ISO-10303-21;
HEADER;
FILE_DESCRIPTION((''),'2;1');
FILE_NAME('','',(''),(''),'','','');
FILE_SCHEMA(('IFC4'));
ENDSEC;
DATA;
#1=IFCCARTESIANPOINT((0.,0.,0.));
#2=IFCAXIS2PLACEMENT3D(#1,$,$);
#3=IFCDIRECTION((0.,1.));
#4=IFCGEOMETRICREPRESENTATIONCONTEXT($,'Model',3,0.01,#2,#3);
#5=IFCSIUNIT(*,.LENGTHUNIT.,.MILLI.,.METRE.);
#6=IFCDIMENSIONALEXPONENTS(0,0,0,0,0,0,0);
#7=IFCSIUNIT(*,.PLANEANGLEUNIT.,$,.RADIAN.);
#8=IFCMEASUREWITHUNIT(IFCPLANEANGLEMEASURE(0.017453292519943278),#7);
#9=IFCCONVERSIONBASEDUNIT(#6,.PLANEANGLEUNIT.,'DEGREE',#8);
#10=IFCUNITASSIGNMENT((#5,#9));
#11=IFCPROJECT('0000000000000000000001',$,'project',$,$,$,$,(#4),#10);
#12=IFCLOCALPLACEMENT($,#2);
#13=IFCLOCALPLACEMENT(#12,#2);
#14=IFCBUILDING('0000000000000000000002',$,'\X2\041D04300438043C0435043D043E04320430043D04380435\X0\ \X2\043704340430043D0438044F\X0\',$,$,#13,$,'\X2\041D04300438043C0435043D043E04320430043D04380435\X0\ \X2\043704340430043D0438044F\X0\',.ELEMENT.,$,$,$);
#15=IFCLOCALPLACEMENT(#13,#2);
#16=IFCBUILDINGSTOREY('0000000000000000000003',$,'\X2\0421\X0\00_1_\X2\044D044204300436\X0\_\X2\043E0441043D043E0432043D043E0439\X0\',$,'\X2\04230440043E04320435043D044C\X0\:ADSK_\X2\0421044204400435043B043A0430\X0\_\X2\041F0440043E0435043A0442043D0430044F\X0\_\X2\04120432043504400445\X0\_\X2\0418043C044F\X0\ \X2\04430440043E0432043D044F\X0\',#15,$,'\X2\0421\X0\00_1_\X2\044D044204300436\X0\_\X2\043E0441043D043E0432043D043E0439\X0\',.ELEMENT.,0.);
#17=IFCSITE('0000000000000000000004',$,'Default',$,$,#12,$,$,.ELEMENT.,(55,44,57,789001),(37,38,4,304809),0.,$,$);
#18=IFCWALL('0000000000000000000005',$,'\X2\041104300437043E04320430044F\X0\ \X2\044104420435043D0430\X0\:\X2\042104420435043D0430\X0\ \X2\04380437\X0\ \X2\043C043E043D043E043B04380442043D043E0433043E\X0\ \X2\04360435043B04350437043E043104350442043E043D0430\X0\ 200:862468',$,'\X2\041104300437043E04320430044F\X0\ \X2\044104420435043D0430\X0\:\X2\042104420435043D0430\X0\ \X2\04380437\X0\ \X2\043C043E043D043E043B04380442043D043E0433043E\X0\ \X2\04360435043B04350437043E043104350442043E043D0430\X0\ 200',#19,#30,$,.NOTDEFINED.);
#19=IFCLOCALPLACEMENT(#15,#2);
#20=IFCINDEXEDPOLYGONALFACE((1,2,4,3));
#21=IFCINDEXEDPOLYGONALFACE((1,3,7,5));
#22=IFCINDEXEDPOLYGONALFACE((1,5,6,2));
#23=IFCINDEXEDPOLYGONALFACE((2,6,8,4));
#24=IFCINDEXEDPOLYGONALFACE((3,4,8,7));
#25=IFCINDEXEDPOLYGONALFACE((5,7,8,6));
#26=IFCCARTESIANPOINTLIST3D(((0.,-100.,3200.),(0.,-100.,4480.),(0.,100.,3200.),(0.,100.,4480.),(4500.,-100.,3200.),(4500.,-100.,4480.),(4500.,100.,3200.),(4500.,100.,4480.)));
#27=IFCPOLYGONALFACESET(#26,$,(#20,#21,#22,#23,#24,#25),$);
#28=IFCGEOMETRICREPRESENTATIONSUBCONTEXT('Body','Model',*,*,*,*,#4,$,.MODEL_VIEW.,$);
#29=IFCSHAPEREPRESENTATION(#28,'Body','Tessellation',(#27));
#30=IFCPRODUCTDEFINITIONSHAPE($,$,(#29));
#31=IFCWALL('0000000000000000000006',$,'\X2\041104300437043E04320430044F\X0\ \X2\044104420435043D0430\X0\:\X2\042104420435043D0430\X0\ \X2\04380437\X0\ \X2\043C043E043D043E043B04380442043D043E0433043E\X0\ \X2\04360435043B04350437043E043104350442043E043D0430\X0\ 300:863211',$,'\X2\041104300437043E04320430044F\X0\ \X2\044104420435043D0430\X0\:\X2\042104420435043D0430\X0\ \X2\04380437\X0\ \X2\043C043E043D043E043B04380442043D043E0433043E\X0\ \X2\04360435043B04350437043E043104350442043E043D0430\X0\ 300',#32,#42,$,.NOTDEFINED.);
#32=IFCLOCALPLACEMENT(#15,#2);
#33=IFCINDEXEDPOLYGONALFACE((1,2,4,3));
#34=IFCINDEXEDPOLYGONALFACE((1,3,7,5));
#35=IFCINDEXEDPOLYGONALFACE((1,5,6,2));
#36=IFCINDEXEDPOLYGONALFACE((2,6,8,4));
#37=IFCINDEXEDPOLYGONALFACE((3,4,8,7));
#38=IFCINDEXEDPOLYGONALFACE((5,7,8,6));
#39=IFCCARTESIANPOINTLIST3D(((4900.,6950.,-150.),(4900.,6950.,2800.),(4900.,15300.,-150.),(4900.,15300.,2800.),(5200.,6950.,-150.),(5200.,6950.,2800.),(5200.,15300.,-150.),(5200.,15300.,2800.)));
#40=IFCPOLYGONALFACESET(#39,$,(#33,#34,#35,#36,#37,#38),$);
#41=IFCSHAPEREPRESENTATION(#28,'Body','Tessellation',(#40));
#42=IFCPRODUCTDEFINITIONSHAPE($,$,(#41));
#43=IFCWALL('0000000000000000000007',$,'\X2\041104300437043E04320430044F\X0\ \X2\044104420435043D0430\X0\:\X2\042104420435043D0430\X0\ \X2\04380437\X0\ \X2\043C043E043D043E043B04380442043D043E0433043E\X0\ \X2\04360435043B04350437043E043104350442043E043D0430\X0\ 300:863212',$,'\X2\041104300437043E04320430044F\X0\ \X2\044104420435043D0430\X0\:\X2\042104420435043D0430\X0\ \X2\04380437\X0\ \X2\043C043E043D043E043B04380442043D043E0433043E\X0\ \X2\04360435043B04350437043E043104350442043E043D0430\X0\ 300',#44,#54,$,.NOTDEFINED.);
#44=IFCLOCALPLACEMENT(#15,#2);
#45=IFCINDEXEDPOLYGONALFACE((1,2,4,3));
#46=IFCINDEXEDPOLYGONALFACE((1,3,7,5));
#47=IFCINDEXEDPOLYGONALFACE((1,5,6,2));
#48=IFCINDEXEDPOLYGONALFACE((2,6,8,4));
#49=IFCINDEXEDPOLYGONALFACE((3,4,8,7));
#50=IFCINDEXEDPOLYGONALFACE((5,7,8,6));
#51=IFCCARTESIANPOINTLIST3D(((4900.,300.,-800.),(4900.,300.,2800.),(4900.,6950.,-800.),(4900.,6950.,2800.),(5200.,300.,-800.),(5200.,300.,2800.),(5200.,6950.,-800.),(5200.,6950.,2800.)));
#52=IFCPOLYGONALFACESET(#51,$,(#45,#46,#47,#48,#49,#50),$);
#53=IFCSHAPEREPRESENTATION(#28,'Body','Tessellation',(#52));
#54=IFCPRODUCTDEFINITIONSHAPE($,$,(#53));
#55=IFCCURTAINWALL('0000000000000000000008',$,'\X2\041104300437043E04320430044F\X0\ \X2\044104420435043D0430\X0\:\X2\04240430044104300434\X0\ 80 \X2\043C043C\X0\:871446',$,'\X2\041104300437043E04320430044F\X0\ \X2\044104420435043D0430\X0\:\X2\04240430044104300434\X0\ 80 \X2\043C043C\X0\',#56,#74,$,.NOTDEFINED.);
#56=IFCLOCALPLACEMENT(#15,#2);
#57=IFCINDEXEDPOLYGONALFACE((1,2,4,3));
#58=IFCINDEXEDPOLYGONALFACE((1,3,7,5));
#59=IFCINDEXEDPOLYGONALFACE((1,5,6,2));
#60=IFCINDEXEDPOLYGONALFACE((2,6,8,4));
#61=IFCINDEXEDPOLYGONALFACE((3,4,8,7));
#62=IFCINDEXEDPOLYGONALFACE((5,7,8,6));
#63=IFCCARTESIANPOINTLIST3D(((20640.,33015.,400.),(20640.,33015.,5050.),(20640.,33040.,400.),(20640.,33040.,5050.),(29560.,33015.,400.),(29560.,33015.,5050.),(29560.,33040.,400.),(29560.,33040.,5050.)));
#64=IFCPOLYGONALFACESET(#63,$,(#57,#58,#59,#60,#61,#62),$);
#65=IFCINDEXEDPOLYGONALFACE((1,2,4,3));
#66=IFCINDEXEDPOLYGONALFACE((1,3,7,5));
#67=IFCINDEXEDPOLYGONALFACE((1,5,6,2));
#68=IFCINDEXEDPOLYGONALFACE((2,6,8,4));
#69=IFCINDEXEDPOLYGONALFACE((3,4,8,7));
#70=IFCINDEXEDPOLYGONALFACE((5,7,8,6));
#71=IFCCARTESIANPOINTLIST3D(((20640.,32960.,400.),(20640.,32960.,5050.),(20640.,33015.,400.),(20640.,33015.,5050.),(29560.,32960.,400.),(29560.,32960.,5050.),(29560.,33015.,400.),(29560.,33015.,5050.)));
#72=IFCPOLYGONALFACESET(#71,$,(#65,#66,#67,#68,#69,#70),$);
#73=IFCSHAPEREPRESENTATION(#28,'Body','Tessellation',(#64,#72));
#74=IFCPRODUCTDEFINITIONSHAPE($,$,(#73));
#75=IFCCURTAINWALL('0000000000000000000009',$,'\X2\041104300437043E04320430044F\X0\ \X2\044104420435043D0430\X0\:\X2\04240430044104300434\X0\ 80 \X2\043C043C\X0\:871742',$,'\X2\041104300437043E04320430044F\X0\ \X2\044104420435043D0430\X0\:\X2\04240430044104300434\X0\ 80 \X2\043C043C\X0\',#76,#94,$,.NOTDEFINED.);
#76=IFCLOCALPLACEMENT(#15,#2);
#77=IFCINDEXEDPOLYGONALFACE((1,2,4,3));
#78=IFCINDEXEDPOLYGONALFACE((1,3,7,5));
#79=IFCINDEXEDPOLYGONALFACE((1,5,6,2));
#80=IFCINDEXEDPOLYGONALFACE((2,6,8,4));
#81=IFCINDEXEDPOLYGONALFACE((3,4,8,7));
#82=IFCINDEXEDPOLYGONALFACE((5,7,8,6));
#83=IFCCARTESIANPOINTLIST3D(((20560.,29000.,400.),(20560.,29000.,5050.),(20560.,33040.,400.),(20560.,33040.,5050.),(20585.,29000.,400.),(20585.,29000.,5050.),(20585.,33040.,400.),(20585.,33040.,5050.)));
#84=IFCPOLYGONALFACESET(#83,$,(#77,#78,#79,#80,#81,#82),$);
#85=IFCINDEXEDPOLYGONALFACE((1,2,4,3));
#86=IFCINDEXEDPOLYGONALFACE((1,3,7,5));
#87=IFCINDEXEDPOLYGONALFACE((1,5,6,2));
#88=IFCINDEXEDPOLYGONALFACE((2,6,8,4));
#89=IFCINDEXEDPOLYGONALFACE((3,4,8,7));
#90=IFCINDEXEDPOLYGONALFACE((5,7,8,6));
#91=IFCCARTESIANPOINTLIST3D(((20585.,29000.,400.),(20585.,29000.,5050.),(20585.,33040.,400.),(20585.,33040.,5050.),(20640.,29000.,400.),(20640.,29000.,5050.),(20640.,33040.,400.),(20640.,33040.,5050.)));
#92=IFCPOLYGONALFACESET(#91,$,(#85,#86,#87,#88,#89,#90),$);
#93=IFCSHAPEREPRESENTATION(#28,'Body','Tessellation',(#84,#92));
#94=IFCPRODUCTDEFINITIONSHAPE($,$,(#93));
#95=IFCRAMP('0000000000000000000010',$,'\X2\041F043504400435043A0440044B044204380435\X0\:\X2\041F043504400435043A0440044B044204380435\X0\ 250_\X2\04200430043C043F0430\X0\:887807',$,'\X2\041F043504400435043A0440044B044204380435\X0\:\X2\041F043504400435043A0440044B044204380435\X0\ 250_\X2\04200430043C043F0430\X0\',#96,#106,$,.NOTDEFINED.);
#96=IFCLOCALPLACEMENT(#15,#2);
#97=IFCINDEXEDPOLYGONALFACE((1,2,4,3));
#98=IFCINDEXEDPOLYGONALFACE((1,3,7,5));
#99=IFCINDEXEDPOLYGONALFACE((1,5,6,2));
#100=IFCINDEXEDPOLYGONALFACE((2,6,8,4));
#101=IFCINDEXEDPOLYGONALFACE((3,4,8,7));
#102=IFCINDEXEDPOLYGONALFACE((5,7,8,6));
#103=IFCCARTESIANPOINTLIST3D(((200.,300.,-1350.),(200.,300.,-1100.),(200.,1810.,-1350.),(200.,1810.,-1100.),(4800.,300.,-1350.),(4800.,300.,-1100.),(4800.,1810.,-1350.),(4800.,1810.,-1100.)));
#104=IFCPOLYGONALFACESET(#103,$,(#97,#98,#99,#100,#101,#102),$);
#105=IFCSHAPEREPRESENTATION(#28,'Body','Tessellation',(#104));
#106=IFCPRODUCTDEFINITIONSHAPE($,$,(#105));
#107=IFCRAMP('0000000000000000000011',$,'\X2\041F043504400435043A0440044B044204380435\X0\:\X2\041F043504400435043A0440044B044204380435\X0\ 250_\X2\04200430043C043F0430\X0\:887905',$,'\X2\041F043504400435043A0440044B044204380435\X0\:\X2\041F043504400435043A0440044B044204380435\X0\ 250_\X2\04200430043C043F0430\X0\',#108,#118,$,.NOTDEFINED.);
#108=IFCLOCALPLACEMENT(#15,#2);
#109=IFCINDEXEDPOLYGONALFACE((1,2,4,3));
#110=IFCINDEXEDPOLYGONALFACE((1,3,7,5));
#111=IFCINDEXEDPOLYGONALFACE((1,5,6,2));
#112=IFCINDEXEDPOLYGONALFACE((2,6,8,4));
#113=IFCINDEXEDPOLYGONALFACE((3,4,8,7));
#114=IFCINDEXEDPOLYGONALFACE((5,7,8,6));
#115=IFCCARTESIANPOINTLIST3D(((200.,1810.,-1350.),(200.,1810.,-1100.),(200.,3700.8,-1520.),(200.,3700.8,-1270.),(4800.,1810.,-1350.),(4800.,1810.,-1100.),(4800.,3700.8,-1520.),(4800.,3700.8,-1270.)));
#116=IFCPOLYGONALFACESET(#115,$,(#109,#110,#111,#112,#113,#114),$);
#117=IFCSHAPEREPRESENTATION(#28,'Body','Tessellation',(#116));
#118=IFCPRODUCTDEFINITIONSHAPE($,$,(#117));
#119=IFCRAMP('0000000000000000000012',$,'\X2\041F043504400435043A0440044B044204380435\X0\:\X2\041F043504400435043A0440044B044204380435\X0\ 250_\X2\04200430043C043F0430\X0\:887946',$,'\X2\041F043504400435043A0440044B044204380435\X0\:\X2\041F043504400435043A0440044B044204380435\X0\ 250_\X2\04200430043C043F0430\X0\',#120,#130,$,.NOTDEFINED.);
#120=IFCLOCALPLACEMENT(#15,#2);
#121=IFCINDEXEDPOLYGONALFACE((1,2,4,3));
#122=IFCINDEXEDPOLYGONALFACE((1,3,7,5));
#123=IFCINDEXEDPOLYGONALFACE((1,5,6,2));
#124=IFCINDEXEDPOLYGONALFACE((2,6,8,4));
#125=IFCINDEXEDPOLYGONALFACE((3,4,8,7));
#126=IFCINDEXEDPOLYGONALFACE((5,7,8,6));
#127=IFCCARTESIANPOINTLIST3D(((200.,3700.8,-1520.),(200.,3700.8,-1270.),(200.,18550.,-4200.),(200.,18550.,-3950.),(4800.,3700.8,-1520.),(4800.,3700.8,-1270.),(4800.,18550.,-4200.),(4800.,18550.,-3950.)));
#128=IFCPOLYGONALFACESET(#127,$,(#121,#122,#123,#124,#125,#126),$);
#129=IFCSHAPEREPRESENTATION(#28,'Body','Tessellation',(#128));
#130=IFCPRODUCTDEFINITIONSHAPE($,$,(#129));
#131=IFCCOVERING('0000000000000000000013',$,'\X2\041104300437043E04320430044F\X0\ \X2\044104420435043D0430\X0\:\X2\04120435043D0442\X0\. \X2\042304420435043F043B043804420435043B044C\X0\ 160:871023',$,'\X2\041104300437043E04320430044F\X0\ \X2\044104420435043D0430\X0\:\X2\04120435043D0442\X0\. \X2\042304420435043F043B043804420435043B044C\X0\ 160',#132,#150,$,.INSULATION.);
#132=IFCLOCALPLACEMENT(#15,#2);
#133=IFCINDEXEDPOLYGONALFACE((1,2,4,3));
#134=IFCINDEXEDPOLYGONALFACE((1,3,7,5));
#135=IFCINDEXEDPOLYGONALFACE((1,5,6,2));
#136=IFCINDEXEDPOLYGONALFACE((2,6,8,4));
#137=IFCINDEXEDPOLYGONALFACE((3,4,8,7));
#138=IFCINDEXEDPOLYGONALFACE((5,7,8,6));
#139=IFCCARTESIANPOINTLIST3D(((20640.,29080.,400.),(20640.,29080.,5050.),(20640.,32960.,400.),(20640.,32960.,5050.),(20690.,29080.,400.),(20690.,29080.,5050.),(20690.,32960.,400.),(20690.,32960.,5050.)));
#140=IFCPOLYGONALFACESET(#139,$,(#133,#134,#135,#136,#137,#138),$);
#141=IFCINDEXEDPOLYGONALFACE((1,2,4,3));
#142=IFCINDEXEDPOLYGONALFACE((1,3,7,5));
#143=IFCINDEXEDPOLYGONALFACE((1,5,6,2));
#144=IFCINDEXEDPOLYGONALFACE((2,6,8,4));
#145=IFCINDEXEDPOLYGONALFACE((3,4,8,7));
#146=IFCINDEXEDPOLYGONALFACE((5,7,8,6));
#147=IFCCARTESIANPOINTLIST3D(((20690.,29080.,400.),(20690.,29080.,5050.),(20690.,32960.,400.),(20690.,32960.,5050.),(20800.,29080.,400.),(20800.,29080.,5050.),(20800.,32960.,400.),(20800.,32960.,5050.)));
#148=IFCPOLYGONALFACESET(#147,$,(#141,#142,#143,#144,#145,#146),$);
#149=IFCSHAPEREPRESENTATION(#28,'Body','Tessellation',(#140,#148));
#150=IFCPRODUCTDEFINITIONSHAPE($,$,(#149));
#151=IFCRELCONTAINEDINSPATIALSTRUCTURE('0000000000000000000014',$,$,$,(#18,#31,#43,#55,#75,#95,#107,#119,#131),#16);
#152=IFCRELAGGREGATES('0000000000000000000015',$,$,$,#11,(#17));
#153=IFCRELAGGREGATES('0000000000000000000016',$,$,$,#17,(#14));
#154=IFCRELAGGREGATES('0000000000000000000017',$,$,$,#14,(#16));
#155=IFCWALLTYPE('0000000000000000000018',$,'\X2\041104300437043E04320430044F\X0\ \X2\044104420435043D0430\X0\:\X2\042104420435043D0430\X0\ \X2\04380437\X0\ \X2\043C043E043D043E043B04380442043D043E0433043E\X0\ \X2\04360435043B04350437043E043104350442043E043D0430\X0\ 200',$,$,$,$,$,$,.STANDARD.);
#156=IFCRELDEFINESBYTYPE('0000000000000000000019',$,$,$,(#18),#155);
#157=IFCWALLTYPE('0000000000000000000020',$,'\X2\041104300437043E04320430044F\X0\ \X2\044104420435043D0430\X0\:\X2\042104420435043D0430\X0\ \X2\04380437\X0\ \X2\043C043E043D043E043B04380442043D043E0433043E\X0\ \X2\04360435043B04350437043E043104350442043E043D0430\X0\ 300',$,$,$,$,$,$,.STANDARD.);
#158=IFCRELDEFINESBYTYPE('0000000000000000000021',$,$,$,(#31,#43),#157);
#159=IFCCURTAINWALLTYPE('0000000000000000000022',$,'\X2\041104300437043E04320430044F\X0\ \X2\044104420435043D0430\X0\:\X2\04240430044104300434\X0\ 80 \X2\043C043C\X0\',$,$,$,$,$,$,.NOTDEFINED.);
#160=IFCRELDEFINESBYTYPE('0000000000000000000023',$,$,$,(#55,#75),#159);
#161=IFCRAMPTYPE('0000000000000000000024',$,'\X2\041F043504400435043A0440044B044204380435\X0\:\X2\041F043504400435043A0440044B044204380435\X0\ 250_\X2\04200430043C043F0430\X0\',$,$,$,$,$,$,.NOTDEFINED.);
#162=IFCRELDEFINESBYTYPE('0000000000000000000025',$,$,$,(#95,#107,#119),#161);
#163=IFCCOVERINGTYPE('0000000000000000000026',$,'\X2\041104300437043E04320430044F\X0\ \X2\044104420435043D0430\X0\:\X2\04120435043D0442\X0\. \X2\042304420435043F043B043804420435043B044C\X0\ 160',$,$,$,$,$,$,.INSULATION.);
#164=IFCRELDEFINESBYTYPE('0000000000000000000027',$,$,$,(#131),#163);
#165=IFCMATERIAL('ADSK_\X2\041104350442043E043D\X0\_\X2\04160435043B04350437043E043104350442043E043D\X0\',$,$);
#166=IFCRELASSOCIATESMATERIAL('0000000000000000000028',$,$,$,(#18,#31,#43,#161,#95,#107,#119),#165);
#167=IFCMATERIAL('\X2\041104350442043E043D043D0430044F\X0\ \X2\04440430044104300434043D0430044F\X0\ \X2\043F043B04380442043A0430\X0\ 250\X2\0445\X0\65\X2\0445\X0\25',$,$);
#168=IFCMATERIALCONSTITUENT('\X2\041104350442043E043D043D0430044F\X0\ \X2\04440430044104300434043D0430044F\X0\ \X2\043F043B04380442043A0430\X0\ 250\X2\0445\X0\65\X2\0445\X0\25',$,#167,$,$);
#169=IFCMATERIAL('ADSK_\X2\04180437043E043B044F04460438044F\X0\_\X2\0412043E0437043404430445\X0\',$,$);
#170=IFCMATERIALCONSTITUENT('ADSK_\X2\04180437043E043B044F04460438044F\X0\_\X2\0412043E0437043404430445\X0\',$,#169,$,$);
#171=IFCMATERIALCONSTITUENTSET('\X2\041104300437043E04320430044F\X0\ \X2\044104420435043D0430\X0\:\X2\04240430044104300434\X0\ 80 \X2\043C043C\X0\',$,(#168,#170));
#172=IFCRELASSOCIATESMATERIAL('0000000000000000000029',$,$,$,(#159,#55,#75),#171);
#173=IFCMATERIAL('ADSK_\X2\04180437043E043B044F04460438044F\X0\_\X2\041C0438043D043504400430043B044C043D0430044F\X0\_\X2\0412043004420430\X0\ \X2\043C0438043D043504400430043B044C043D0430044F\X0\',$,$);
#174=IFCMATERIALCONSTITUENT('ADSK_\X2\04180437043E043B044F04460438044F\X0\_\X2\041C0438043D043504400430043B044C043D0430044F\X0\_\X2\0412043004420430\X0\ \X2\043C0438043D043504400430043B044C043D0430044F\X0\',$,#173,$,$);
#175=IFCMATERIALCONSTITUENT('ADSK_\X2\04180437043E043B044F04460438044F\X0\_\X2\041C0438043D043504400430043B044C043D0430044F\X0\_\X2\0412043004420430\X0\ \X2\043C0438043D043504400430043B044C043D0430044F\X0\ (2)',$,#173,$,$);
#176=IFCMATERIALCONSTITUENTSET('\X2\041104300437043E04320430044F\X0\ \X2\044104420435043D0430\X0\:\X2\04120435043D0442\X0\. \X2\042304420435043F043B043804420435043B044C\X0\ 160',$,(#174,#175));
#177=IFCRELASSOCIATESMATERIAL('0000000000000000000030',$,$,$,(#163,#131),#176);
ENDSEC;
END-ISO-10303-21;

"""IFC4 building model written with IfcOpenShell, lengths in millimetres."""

from ifc_helpers import new_model, entity, si_unit, converted_unit, direction, frame, frame_2d, origin, place, context, subcontext, project, spatial, indexed_curve, rectangle, outline, extrude, material, constituent, constituent_set, type_object, element, save


model = new_model("IFC4")

# Units and contexts
model_context = context("Model", 3, precision=0.01, world=origin(), true_north=direction((0.0, 1.0)))
body_context = subcontext(model_context, "Body", "Model", "MODEL_VIEW")
ifc_project = project(units=[si_unit("LENGTHUNIT", "METRE", prefix="MILLI"), converted_unit("PLANEANGLEUNIT", "DEGREE", entity("IfcPlaneAngleMeasure", 0.017453292519943278), si_unit("PLANEANGLEUNIT", "RADIAN"), dimensions=[0, 0, 0, 0, 0, 0, 0])], contexts=[model_context])

# Site, building, storey
site_placement = place(None, origin())
site = spatial("IfcSite", under=ifc_project, at=site_placement, Name="Default", CompositionType="ELEMENT", RefLatitude=(55, 44, 57, 789001), RefLongitude=(37, 38, 4, 304809), RefElevation=0.0)
building_placement = place(site_placement, origin())
building = spatial("IfcBuilding", under=site, at=building_placement, Name="Наименование здания", LongName="Наименование здания", CompositionType="ELEMENT")
storey_placement = place(building_placement, origin())
storey = spatial("IfcBuildingStorey", under=building, at=storey_placement, Name="С00_1_этаж_основной", ObjectType="Уровень:ADSK_Стрелка_Проектная_Вверх_Имя уровня", LongName="С00_1_этаж_основной", CompositionType="ELEMENT", Elevation=0.0)

# Shared definitions
ifc_material_1 = material(Name="ADSK_Бетон_Железобетон")

# Walls
wall_type_1 = type_object("IfcWallType", Name="Базовая стена:Стена из монолитного железобетона 200", PredefinedType="STANDARD")
wall_1_placement = place(storey_placement, frame((0.0, 0.0, 3200.0)))
element("IfcWall", 1, at=wall_1_placement, inside=storey, type_object=wall_type_1, material=ifc_material_1, Name="Базовая стена:Стена из монолитного железобетона 200:862468", ObjectType="Базовая стена:Стена из монолитного железобетона 200", PredefinedType="NOTDEFINED", context=body_context, shape_type="SweptSolid", body=[
    extrude(outline(indexed_curve([(4500.0, 100.0), (0.0, 100.0), (0.0, -100.0), (4500.0, -100.0), (4500.0, 100.0)], self_intersect=False)), origin(), (0.0, 0.0, 1.0), 1280.0),
])
wall_type_2 = type_object("IfcWallType", Name="Базовая стена:Стена из монолитного железобетона 300", PredefinedType="STANDARD")
wall_2_placement = place(storey_placement, frame((5050.0, 15300.0, -150.0), z_axis=(0.0, 0.0, 1.0), x_axis=(0.0, -1.0, 0.0)))
element("IfcWall", 2, at=wall_2_placement, inside=storey, type_object=wall_type_2, material=ifc_material_1, Name="Базовая стена:Стена из монолитного железобетона 300:863211", ObjectType="Базовая стена:Стена из монолитного железобетона 300", PredefinedType="NOTDEFINED", context=body_context, shape_type="SweptSolid", body=[
    extrude(outline(indexed_curve([(8350.0, 150.0), (0.0, 150.0), (0.0, -150.0), (8350.0, -150.0), (8350.0, 150.0)], self_intersect=False)), origin(), (0.0, 0.0, 1.0), 2950.0),
])
wall_3_placement = place(storey_placement, frame((5050.0, 6950.0, -800.0), z_axis=(0.0, 0.0, 1.0), x_axis=(0.0, -1.0, 0.0)))
element("IfcWall", 3, at=wall_3_placement, inside=storey, type_object=wall_type_2, material=ifc_material_1, Name="Базовая стена:Стена из монолитного железобетона 300:863212", ObjectType="Базовая стена:Стена из монолитного железобетона 300", PredefinedType="NOTDEFINED", context=body_context, shape_type="SweptSolid", body=[
    extrude(outline(indexed_curve([(6650.0, 150.0), (0.0, 150.0), (0.0, -150.0), (6650.0, -150.0), (6650.0, 150.0)], self_intersect=False)), origin(), (0.0, 0.0, 1.0), 3600.0),
])

# Curtain walls
ifc_material_2 = material(Name="Бетонная фасадная плитка 250х65х25")
ifc_constituent_1 = constituent(ifc_material_2, Name="Бетонная фасадная плитка 250х65х25")
ifc_material_3 = material(Name="ADSK_Изоляция_Воздух")
ifc_constituent_2 = constituent(ifc_material_3, Name="ADSK_Изоляция_Воздух")
ifc_constituent_set_1 = constituent_set(constituents=[ifc_constituent_1, ifc_constituent_2], Name="Базовая стена:Фасад 80 мм")
curtain_wall_type = type_object("IfcCurtainWallType", Name="Базовая стена:Фасад 80 мм", PredefinedType="NOTDEFINED", material=ifc_constituent_set_1)
curtain_wall_1_placement = place(storey_placement, frame((20640.0, 33000.0, 400.0)))
element("IfcCurtainWall", 4, at=curtain_wall_1_placement, inside=storey, type_object=curtain_wall_type, material=ifc_constituent_set_1, Name="Базовая стена:Фасад 80 мм:871446", ObjectType="Базовая стена:Фасад 80 мм", PredefinedType="NOTDEFINED", context=body_context, shape_type="SweptSolid", body=[
    extrude(outline(indexed_curve([(-12.5, -4460.0), (12.5, -4460.0), (12.5, 4460.0), (-12.5, 4460.0), (-12.5, -4460.0)], self_intersect=False)), frame((4460.0, 27.5, 0.0), z_axis=(0.0, 0.0, 1.0), x_axis=(0.0, -1.0, 0.0)), (0.0, 0.0, 1.0), 4650.0),
    extrude(outline(indexed_curve([(-27.5, -4460.0), (27.5, -4460.0), (27.5, 4460.0), (-27.5, 4460.0), (-27.5, -4460.0)], self_intersect=False)), frame((4460.0, -12.5, 0.0), z_axis=(0.0, 0.0, 1.0), x_axis=(0.0, 1.0, 0.0)), (0.0, 0.0, 1.0), 4650.0),
])
curtain_wall_2_placement = place(storey_placement, frame((20600.0, 29000.0, 400.0), z_axis=(0.0, 0.0, 1.0), x_axis=(0.0, 1.0, 0.0)))
element("IfcCurtainWall", 5, at=curtain_wall_2_placement, inside=storey, type_object=curtain_wall_type, material=ifc_constituent_set_1, Name="Базовая стена:Фасад 80 мм:871742", ObjectType="Базовая стена:Фасад 80 мм", PredefinedType="NOTDEFINED", context=body_context, shape_type="SweptSolid", body=[
    extrude(outline(indexed_curve([(-12.5, -2020.0), (12.5, -2020.0), (12.5, 2020.0), (-12.5, 2020.0), (-12.5, -2020.0)], self_intersect=False)), frame((2020.0, 27.5, 0.0), z_axis=(0.0, 0.0, 1.0), x_axis=(0.0, -1.0, 0.0)), (0.0, 0.0, 1.0), 4650.0),
    extrude(outline(indexed_curve([(-27.5, -2020.0), (27.5, -2020.0), (27.5, 2020.0), (-27.5, 2020.0), (-27.5, -2020.0)], self_intersect=False)), frame((2020.0, -12.5, 0.0), z_axis=(0.0, 0.0, 1.0), x_axis=(0.0, 1.0, 0.0)), (0.0, 0.0, 1.0), 4650.0),
])

# Ramps
ramp_type = type_object("IfcRampType", Name="Перекрытие:Перекрытие 250_Рампа", PredefinedType="NOTDEFINED", material=ifc_material_1)
ramp_1_placement = place(storey_placement, origin())
element("IfcRamp", 6, at=ramp_1_placement, inside=storey, type_object=ramp_type, material=ifc_material_1, Name="Перекрытие:Перекрытие 250_Рампа:887807", ObjectType="Перекрытие:Перекрытие 250_Рампа", PredefinedType="NOTDEFINED", context=body_context, shape_type="SweptSolid", body=[
    extrude(outline(indexed_curve([(-755.0, -2300.0), (755.0, -2300.0), (755.0, 2300.0), (-755.0, 2300.0), (-755.0, -2300.0)], self_intersect=False)), frame((2500.0, 1055.0, -1100.0), z_axis=(0.0, 0.0, -1.0), x_axis=(0.0, 1.0, 0.0)), (0.0, 0.0, 1.0), 250.0),
])
ramp_2_placement = place(storey_placement, frame((200.0, 1810.0, -1520.0)))
element("IfcRamp", 7, at=ramp_2_placement, inside=storey, type_object=ramp_type, material=ifc_material_1, Name="Перекрытие:Перекрытие 250_Рампа:887905", ObjectType="Перекрытие:Перекрытие 250_Рампа", PredefinedType="NOTDEFINED", context=body_context, shape_type="SweptSolid", body=[
    extrude(rectangle(XDim=1898.5, YDim=4600.0, at=frame_2d((0.0, 0.0), x_axis=(0.0, 1.0))), frame((2300.0, 945.4, 335.0), z_axis=(0.0, 0.089546, 0.995983), x_axis=(1.0, 0.0, 0.0)), (0.0, 0.089546, -0.995983), 250.0),
])
ramp_3_placement = place(storey_placement, frame((200.0, 3700.8, -4200.0)))
element("IfcRamp", 8, at=ramp_3_placement, inside=storey, type_object=ramp_type, material=ifc_material_1, Name="Перекрытие:Перекрытие 250_Рампа:887946", ObjectType="Перекрытие:Перекрытие 250_Рампа", PredefinedType="NOTDEFINED", context=body_context, shape_type="SweptSolid", body=[
    extrude(rectangle(XDim=15089.1, YDim=4600.0, at=frame_2d((0.0, 0.0), x_axis=(0.0, 1.0))), frame((2300.0, 7424.6, 1590.0), z_axis=(0.0, 0.177612, 0.984101), x_axis=(1.0, 0.0, 0.0)), (0.0, 0.177612, -0.984101), 250.0),
])

# Covering
ifc_material_4 = material(Name="ADSK_Изоляция_Минеральная_Вата минеральная")
ifc_constituent_3 = constituent(ifc_material_4, Name="ADSK_Изоляция_Минеральная_Вата минеральная")
ifc_constituent_4 = constituent(ifc_material_4, Name="ADSK_Изоляция_Минеральная_Вата минеральная (2)")
ifc_constituent_set_2 = constituent_set(constituents=[ifc_constituent_3, ifc_constituent_4], Name="Базовая стена:Вент. Утеплитель 160")
covering_type = type_object("IfcCoveringType", Name="Базовая стена:Вент. Утеплитель 160", PredefinedType="INSULATION", material=ifc_constituent_set_2)
covering_placement = place(storey_placement, frame((20720.0, 29080.0, 400.0), z_axis=(0.0, 0.0, 1.0), x_axis=(0.0, 1.0, 0.0)))
element("IfcCovering", 9, at=covering_placement, inside=storey, type_object=covering_type, material=ifc_constituent_set_2, Name="Базовая стена:Вент. Утеплитель 160:871023", ObjectType="Базовая стена:Вент. Утеплитель 160", PredefinedType="INSULATION", context=body_context, shape_type="SweptSolid", body=[
    extrude(outline(indexed_curve([(-25.0, -1940.0), (25.0, -1940.0), (25.0, 1940.0), (-25.0, 1940.0), (-25.0, -1940.0)], self_intersect=False)), frame((1940.0, 55.0, 0.0), z_axis=(0.0, 0.0, 1.0), x_axis=(0.0, -1.0, 0.0)), (0.0, 0.0, 1.0), 4650.0),
    extrude(outline(indexed_curve([(-55.0, -1940.0), (55.0, -1940.0), (55.0, 1940.0), (-55.0, 1940.0), (-55.0, -1940.0)], self_intersect=False)), frame((1940.0, -25.0, 0.0), z_axis=(0.0, 0.0, 1.0), x_axis=(0.0, 1.0, 0.0)), (0.0, 0.0, 1.0), 4650.0),
])

save(model, "model.ifc")
